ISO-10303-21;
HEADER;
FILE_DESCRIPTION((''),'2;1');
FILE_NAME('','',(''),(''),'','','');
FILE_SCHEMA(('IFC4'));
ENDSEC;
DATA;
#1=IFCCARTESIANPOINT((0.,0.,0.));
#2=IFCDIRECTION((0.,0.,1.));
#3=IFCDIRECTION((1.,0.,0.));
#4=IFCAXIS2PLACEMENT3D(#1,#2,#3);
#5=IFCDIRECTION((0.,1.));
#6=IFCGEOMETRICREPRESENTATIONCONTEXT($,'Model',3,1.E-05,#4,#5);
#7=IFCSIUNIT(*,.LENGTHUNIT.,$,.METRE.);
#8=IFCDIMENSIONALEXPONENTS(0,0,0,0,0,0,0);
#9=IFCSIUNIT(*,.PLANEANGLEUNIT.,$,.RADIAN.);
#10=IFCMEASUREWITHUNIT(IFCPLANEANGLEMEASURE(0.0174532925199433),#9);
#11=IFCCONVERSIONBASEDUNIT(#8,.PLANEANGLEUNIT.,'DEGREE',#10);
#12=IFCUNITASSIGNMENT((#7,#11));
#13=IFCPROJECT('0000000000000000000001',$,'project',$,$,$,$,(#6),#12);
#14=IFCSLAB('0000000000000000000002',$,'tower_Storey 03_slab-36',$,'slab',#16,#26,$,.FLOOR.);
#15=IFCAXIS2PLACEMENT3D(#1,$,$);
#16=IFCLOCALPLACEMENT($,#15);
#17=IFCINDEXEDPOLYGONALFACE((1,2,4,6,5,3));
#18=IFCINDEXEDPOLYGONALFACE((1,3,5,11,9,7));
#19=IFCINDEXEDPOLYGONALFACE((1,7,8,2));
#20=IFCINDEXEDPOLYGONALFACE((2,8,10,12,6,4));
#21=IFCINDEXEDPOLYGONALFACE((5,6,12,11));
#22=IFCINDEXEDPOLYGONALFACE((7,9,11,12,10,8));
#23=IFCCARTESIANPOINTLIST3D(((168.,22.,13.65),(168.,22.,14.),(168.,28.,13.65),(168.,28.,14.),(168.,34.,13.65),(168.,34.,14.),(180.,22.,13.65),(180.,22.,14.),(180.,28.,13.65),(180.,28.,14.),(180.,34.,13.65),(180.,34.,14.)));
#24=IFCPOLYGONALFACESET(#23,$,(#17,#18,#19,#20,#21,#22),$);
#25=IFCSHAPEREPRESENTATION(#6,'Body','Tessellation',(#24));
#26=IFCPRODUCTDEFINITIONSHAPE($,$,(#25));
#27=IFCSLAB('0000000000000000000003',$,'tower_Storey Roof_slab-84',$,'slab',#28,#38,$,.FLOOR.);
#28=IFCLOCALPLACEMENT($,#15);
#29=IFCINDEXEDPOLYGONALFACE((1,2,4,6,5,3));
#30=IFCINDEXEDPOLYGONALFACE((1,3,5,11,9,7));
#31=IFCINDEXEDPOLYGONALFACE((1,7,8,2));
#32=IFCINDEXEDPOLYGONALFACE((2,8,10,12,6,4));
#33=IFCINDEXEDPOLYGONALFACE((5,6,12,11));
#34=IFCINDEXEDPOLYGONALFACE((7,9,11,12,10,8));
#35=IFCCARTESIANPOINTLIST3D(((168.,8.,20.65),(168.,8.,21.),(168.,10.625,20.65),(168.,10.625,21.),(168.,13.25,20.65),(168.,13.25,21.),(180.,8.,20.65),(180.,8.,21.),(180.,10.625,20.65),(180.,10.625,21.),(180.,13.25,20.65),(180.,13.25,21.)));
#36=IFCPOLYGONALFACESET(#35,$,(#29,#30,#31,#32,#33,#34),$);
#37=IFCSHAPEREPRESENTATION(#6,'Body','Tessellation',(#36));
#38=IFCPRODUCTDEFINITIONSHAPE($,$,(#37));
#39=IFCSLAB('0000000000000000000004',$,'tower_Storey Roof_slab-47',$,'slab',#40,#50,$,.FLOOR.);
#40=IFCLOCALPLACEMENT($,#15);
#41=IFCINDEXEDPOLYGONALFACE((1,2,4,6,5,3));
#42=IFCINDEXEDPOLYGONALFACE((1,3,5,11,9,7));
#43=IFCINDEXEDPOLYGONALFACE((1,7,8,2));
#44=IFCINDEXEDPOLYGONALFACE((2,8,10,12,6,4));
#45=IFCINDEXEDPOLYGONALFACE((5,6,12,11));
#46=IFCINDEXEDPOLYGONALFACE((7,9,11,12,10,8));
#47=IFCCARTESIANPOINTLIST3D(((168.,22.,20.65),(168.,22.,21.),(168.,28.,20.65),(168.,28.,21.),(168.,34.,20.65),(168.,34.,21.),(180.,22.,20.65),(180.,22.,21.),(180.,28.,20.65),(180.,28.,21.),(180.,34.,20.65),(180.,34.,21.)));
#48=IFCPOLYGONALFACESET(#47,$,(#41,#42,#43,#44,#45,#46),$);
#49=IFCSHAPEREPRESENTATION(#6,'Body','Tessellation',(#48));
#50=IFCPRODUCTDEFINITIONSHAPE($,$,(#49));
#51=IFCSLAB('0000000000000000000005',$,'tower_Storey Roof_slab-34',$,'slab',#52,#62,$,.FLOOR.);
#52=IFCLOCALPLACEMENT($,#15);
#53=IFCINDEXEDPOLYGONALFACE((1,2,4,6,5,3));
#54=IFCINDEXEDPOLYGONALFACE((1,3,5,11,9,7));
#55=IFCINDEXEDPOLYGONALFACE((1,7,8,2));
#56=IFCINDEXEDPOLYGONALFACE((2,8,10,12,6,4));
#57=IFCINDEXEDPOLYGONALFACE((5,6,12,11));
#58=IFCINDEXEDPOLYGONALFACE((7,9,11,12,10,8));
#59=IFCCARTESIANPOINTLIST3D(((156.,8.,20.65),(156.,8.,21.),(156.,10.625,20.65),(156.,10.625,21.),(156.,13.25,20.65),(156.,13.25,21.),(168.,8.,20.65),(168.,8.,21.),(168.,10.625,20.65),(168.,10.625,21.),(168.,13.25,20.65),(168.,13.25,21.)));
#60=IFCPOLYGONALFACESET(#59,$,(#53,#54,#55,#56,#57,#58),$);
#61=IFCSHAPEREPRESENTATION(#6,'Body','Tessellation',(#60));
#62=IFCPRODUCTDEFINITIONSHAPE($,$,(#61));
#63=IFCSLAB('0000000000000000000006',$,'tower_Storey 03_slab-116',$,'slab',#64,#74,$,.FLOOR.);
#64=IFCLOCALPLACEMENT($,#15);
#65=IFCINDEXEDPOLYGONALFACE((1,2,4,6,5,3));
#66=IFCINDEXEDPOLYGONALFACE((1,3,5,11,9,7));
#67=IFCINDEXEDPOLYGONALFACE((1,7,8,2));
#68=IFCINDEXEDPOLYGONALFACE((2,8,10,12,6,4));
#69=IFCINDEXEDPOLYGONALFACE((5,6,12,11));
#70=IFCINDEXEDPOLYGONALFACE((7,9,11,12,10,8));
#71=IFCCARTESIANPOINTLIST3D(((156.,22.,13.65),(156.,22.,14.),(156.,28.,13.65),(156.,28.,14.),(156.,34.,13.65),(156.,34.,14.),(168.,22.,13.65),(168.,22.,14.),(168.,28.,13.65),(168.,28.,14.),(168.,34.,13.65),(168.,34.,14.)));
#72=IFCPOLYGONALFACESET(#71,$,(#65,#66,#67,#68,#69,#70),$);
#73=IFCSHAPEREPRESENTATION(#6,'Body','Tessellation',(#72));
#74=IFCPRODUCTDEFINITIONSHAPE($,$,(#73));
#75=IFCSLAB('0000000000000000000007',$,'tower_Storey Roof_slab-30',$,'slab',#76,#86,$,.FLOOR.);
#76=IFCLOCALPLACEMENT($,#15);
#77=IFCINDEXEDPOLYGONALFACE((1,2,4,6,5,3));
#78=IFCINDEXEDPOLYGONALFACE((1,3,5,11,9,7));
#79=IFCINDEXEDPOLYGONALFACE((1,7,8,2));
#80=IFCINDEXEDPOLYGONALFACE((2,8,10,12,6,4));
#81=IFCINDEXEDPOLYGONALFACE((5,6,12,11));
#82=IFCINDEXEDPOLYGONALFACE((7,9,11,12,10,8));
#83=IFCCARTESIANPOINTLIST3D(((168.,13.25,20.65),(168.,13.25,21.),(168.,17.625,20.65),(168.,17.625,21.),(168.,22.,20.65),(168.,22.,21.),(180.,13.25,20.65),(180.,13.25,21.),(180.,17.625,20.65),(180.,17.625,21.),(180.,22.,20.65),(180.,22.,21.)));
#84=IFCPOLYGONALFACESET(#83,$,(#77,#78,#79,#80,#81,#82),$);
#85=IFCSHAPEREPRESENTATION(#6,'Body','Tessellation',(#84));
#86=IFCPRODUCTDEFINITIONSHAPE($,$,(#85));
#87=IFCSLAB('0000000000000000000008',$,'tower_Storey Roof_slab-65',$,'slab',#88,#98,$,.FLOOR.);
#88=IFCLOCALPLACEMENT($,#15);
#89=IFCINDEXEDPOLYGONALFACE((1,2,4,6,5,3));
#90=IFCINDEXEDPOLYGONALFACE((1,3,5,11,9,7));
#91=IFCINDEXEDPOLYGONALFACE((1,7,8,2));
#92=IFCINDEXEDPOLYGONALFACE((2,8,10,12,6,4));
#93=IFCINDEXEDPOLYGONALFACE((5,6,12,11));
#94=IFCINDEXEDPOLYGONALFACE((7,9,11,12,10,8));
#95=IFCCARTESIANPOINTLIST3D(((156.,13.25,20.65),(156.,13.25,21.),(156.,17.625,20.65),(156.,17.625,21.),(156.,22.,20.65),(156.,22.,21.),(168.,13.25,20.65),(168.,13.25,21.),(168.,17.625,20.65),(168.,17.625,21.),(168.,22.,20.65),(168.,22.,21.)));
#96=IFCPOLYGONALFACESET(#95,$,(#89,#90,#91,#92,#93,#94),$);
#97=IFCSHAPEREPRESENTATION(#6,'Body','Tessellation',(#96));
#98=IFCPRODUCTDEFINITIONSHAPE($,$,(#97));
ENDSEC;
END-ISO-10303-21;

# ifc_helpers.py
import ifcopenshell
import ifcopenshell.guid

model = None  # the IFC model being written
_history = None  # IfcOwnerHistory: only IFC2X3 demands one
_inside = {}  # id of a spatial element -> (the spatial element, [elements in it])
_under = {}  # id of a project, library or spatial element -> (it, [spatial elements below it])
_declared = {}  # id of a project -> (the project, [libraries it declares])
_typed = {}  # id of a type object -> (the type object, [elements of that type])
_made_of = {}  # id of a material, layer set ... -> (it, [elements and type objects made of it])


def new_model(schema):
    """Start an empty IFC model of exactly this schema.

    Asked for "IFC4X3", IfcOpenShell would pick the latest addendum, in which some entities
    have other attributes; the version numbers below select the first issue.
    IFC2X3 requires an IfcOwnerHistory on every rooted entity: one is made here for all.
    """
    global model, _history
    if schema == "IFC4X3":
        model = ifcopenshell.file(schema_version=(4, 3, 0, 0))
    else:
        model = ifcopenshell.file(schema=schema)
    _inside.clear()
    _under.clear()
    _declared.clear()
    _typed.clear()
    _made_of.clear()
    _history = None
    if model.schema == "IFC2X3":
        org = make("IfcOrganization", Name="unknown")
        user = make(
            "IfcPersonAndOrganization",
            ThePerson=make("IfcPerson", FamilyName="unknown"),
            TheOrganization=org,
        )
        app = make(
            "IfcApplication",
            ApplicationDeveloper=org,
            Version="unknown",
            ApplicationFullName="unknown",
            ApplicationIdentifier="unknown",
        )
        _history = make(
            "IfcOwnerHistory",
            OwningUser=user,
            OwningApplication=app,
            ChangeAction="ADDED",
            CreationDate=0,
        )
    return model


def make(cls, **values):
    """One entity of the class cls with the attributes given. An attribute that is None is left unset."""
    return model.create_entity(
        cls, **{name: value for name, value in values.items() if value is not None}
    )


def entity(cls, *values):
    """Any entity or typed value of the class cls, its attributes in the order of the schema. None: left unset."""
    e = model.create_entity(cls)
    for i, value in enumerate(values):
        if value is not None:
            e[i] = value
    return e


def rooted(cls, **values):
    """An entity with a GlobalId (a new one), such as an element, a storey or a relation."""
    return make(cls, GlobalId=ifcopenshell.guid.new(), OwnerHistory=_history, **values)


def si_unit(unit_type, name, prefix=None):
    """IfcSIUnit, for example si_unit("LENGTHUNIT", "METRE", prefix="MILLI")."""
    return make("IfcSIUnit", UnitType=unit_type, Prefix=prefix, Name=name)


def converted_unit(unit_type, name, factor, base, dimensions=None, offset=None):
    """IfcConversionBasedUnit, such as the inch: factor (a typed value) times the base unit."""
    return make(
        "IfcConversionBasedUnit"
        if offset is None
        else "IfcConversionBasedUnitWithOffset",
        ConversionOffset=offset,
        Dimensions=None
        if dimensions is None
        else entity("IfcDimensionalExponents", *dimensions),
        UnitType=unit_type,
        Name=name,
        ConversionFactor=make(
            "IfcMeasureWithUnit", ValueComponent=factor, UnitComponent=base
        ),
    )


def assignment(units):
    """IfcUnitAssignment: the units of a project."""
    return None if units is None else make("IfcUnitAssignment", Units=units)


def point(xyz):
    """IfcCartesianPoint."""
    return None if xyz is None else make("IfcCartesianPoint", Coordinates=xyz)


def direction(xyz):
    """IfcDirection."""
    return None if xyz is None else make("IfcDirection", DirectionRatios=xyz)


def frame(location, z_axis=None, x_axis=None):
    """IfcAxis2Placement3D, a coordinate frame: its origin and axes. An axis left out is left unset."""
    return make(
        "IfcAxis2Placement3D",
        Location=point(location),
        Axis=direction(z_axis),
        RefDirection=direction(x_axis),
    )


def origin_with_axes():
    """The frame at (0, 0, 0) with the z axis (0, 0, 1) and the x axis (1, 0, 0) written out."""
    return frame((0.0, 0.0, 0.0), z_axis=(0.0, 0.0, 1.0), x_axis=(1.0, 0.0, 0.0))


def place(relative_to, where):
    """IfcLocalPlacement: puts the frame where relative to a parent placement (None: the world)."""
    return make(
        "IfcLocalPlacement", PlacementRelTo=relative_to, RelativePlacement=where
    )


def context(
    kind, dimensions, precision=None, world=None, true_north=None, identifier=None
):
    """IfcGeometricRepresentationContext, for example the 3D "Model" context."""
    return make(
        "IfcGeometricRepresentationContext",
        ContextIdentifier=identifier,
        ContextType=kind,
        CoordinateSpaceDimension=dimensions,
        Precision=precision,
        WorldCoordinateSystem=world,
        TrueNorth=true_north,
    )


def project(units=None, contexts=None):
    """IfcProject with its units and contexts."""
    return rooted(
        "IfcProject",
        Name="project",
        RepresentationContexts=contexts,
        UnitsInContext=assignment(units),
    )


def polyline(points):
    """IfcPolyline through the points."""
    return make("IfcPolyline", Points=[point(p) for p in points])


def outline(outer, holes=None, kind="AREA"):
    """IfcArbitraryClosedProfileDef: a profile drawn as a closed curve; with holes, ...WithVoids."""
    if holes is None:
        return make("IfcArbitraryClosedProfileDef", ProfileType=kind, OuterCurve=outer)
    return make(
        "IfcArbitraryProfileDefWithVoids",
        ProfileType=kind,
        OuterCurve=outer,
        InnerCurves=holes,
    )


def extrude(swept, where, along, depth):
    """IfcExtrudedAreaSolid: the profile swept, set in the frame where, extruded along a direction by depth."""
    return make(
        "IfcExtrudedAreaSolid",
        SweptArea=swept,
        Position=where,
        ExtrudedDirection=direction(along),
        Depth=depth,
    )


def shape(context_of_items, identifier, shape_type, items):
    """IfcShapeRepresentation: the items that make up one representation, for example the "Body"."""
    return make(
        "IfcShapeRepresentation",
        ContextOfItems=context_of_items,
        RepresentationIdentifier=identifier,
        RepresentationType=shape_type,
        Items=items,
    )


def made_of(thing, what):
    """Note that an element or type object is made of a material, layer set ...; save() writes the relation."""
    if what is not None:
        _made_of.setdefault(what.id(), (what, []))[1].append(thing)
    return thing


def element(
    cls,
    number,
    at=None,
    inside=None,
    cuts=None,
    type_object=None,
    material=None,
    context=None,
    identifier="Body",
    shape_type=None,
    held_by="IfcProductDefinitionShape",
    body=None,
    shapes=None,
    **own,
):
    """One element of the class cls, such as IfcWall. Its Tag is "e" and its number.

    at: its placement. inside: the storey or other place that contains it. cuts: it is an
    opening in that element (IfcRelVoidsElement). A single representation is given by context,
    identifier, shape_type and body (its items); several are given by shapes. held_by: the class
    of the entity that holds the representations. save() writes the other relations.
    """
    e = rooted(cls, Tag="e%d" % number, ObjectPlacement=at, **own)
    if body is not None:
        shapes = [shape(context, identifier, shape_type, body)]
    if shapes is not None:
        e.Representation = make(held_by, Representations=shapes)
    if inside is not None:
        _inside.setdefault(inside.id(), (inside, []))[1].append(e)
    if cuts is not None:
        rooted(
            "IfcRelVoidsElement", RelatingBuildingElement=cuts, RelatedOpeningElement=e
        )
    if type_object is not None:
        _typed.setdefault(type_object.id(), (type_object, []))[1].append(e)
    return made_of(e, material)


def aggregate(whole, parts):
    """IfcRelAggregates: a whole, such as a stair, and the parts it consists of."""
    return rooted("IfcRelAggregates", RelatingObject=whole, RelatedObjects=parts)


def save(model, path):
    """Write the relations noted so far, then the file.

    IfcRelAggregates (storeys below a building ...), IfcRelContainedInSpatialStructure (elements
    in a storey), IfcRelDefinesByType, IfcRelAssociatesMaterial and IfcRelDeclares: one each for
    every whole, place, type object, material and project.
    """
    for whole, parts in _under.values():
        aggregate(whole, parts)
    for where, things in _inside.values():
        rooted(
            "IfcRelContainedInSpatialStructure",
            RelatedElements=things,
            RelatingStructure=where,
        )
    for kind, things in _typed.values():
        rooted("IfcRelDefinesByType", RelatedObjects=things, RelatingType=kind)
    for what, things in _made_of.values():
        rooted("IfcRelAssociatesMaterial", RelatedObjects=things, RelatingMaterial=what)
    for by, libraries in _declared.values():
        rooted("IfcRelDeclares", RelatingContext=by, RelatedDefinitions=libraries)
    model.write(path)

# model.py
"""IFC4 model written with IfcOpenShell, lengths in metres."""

from ifc_helpers import new_model, entity, si_unit, converted_unit, direction, frame, origin_with_axes, place, context, project, polyline, outline, extrude, element, save


model = new_model("IFC4")

# Units and contexts
model_context = context("Model", 3, precision=1e-05, world=origin_with_axes(), true_north=direction((0.0, 1.0)))
ifc_project = project(units=[si_unit("LENGTHUNIT", "METRE"), converted_unit("PLANEANGLEUNIT", "DEGREE", entity("IfcPlaneAngleMeasure", 0.0174532925199433), si_unit("PLANEANGLEUNIT", "RADIAN"), dimensions=[0, 0, 0, 0, 0, 0, 0])], contexts=[model_context])

# Shared definitions
placement_1 = place(None, origin_with_axes())
placement_2 = place(placement_1, frame((0.0, 0.0, 14.0), z_axis=(0.0, 0.0, 1.0), x_axis=(1.0, 0.0, 0.0)))

# Shared definitions
placement_3 = place(placement_1, frame((0.0, 0.0, 21.0), z_axis=(0.0, 0.0, 1.0), x_axis=(1.0, 0.0, 0.0)))

# Slabs
slab_1_placement = place(placement_2, frame((174.0, 28.0, -0.35), z_axis=(0.0, 0.0, 1.0), x_axis=(1.0, 0.0, 0.0)))
element("IfcSlab", 1, at=slab_1_placement, Name="tower_Storey 03_slab-36", ObjectType="slab", PredefinedType="FLOOR", context=model_context, body=[
    extrude(outline(polyline([(-6.0, -6.0, 0.0), (6.0, -6.0, 0.0), (6.0, 0.0, 0.0), (6.0, 6.0, 0.0), (-6.0, 6.0, 0.0), (-6.0, 0.0, 0.0), (-6.0, -6.0, 0.0)])), origin_with_axes(), (0.0, 0.0, 1.0), 0.35),
])
slab_2_placement = place(placement_3, frame((174.0, 10.625, -0.35), z_axis=(0.0, 0.0, 1.0), x_axis=(1.0, 0.0, 0.0)))
element("IfcSlab", 2, at=slab_2_placement, Name="tower_Storey Roof_slab-84", ObjectType="slab", PredefinedType="FLOOR", context=model_context, body=[
    extrude(outline(polyline([(-6.0, -2.625, 0.0), (6.0, -2.625, 0.0), (6.0, 0.0, 0.0), (6.0, 2.625, 0.0), (-6.0, 2.625, 0.0), (-6.0, 0.0, 0.0), (-6.0, -2.625, 0.0)])), origin_with_axes(), (0.0, 0.0, 1.0), 0.35),
])
slab_3_placement = place(placement_3, frame((174.0, 28.0, -0.35), z_axis=(0.0, 0.0, 1.0), x_axis=(1.0, 0.0, 0.0)))
element("IfcSlab", 3, at=slab_3_placement, Name="tower_Storey Roof_slab-47", ObjectType="slab", PredefinedType="FLOOR", context=model_context, body=[
    extrude(outline(polyline([(-6.0, -6.0, 0.0), (6.0, -6.0, 0.0), (6.0, 0.0, 0.0), (6.0, 6.0, 0.0), (-6.0, 6.0, 0.0), (-6.0, 0.0, 0.0), (-6.0, -6.0, 0.0)])), origin_with_axes(), (0.0, 0.0, 1.0), 0.35),
])
slab_4_placement = place(placement_3, frame((162.0, 10.625, -0.35), z_axis=(0.0, 0.0, 1.0), x_axis=(1.0, 0.0, 0.0)))
element("IfcSlab", 4, at=slab_4_placement, Name="tower_Storey Roof_slab-34", ObjectType="slab", PredefinedType="FLOOR", context=model_context, body=[
    extrude(outline(polyline([(-6.0, -2.625, 0.0), (6.0, -2.625, 0.0), (6.0, 0.0, 0.0), (6.0, 2.625, 0.0), (-6.0, 2.625, 0.0), (-6.0, 0.0, 0.0), (-6.0, -2.625, 0.0)])), origin_with_axes(), (0.0, 0.0, 1.0), 0.35),
])
slab_5_placement = place(placement_2, frame((162.0, 28.0, -0.35), z_axis=(0.0, 0.0, 1.0), x_axis=(1.0, 0.0, 0.0)))
element("IfcSlab", 5, at=slab_5_placement, Name="tower_Storey 03_slab-116", ObjectType="slab", PredefinedType="FLOOR", context=model_context, body=[
    extrude(outline(polyline([(-6.0, -6.0, 0.0), (6.0, -6.0, 0.0), (6.0, 0.0, 0.0), (6.0, 6.0, 0.0), (-6.0, 6.0, 0.0), (-6.0, 0.0, 0.0), (-6.0, -6.0, 0.0)])), origin_with_axes(), (0.0, 0.0, 1.0), 0.35),
])
for number, where, z_axis, x_axis, name in (
    (6, (174.0, 17.625, -0.35), (0.0, 0.0, 1.0), (1.0, 0.0, 0.0), "tower_Storey Roof_slab-30"),
    (7, (162.0, 17.625, -0.35), (0.0, 0.0, 1.0), (1.0, 0.0, 0.0), "tower_Storey Roof_slab-65"),
):
    element("IfcSlab", number, at=place(placement_3, frame(where, z_axis=z_axis, x_axis=x_axis)), Name=name, ObjectType="slab", PredefinedType="FLOOR", context=model_context, body=[
        extrude(outline(polyline([(-6.0, 0.0, 0.0), (-6.0, -4.375, 0.0), (6.0, -4.375, 0.0), (6.0, 0.0, 0.0), (6.0, 4.375, 0.0), (-6.0, 4.375, 0.0), (-6.0, 0.0, 0.0)])), origin_with_axes(), (0.0, 0.0, 1.0), 0.35),
    ])

save(model, "model.ifc")
